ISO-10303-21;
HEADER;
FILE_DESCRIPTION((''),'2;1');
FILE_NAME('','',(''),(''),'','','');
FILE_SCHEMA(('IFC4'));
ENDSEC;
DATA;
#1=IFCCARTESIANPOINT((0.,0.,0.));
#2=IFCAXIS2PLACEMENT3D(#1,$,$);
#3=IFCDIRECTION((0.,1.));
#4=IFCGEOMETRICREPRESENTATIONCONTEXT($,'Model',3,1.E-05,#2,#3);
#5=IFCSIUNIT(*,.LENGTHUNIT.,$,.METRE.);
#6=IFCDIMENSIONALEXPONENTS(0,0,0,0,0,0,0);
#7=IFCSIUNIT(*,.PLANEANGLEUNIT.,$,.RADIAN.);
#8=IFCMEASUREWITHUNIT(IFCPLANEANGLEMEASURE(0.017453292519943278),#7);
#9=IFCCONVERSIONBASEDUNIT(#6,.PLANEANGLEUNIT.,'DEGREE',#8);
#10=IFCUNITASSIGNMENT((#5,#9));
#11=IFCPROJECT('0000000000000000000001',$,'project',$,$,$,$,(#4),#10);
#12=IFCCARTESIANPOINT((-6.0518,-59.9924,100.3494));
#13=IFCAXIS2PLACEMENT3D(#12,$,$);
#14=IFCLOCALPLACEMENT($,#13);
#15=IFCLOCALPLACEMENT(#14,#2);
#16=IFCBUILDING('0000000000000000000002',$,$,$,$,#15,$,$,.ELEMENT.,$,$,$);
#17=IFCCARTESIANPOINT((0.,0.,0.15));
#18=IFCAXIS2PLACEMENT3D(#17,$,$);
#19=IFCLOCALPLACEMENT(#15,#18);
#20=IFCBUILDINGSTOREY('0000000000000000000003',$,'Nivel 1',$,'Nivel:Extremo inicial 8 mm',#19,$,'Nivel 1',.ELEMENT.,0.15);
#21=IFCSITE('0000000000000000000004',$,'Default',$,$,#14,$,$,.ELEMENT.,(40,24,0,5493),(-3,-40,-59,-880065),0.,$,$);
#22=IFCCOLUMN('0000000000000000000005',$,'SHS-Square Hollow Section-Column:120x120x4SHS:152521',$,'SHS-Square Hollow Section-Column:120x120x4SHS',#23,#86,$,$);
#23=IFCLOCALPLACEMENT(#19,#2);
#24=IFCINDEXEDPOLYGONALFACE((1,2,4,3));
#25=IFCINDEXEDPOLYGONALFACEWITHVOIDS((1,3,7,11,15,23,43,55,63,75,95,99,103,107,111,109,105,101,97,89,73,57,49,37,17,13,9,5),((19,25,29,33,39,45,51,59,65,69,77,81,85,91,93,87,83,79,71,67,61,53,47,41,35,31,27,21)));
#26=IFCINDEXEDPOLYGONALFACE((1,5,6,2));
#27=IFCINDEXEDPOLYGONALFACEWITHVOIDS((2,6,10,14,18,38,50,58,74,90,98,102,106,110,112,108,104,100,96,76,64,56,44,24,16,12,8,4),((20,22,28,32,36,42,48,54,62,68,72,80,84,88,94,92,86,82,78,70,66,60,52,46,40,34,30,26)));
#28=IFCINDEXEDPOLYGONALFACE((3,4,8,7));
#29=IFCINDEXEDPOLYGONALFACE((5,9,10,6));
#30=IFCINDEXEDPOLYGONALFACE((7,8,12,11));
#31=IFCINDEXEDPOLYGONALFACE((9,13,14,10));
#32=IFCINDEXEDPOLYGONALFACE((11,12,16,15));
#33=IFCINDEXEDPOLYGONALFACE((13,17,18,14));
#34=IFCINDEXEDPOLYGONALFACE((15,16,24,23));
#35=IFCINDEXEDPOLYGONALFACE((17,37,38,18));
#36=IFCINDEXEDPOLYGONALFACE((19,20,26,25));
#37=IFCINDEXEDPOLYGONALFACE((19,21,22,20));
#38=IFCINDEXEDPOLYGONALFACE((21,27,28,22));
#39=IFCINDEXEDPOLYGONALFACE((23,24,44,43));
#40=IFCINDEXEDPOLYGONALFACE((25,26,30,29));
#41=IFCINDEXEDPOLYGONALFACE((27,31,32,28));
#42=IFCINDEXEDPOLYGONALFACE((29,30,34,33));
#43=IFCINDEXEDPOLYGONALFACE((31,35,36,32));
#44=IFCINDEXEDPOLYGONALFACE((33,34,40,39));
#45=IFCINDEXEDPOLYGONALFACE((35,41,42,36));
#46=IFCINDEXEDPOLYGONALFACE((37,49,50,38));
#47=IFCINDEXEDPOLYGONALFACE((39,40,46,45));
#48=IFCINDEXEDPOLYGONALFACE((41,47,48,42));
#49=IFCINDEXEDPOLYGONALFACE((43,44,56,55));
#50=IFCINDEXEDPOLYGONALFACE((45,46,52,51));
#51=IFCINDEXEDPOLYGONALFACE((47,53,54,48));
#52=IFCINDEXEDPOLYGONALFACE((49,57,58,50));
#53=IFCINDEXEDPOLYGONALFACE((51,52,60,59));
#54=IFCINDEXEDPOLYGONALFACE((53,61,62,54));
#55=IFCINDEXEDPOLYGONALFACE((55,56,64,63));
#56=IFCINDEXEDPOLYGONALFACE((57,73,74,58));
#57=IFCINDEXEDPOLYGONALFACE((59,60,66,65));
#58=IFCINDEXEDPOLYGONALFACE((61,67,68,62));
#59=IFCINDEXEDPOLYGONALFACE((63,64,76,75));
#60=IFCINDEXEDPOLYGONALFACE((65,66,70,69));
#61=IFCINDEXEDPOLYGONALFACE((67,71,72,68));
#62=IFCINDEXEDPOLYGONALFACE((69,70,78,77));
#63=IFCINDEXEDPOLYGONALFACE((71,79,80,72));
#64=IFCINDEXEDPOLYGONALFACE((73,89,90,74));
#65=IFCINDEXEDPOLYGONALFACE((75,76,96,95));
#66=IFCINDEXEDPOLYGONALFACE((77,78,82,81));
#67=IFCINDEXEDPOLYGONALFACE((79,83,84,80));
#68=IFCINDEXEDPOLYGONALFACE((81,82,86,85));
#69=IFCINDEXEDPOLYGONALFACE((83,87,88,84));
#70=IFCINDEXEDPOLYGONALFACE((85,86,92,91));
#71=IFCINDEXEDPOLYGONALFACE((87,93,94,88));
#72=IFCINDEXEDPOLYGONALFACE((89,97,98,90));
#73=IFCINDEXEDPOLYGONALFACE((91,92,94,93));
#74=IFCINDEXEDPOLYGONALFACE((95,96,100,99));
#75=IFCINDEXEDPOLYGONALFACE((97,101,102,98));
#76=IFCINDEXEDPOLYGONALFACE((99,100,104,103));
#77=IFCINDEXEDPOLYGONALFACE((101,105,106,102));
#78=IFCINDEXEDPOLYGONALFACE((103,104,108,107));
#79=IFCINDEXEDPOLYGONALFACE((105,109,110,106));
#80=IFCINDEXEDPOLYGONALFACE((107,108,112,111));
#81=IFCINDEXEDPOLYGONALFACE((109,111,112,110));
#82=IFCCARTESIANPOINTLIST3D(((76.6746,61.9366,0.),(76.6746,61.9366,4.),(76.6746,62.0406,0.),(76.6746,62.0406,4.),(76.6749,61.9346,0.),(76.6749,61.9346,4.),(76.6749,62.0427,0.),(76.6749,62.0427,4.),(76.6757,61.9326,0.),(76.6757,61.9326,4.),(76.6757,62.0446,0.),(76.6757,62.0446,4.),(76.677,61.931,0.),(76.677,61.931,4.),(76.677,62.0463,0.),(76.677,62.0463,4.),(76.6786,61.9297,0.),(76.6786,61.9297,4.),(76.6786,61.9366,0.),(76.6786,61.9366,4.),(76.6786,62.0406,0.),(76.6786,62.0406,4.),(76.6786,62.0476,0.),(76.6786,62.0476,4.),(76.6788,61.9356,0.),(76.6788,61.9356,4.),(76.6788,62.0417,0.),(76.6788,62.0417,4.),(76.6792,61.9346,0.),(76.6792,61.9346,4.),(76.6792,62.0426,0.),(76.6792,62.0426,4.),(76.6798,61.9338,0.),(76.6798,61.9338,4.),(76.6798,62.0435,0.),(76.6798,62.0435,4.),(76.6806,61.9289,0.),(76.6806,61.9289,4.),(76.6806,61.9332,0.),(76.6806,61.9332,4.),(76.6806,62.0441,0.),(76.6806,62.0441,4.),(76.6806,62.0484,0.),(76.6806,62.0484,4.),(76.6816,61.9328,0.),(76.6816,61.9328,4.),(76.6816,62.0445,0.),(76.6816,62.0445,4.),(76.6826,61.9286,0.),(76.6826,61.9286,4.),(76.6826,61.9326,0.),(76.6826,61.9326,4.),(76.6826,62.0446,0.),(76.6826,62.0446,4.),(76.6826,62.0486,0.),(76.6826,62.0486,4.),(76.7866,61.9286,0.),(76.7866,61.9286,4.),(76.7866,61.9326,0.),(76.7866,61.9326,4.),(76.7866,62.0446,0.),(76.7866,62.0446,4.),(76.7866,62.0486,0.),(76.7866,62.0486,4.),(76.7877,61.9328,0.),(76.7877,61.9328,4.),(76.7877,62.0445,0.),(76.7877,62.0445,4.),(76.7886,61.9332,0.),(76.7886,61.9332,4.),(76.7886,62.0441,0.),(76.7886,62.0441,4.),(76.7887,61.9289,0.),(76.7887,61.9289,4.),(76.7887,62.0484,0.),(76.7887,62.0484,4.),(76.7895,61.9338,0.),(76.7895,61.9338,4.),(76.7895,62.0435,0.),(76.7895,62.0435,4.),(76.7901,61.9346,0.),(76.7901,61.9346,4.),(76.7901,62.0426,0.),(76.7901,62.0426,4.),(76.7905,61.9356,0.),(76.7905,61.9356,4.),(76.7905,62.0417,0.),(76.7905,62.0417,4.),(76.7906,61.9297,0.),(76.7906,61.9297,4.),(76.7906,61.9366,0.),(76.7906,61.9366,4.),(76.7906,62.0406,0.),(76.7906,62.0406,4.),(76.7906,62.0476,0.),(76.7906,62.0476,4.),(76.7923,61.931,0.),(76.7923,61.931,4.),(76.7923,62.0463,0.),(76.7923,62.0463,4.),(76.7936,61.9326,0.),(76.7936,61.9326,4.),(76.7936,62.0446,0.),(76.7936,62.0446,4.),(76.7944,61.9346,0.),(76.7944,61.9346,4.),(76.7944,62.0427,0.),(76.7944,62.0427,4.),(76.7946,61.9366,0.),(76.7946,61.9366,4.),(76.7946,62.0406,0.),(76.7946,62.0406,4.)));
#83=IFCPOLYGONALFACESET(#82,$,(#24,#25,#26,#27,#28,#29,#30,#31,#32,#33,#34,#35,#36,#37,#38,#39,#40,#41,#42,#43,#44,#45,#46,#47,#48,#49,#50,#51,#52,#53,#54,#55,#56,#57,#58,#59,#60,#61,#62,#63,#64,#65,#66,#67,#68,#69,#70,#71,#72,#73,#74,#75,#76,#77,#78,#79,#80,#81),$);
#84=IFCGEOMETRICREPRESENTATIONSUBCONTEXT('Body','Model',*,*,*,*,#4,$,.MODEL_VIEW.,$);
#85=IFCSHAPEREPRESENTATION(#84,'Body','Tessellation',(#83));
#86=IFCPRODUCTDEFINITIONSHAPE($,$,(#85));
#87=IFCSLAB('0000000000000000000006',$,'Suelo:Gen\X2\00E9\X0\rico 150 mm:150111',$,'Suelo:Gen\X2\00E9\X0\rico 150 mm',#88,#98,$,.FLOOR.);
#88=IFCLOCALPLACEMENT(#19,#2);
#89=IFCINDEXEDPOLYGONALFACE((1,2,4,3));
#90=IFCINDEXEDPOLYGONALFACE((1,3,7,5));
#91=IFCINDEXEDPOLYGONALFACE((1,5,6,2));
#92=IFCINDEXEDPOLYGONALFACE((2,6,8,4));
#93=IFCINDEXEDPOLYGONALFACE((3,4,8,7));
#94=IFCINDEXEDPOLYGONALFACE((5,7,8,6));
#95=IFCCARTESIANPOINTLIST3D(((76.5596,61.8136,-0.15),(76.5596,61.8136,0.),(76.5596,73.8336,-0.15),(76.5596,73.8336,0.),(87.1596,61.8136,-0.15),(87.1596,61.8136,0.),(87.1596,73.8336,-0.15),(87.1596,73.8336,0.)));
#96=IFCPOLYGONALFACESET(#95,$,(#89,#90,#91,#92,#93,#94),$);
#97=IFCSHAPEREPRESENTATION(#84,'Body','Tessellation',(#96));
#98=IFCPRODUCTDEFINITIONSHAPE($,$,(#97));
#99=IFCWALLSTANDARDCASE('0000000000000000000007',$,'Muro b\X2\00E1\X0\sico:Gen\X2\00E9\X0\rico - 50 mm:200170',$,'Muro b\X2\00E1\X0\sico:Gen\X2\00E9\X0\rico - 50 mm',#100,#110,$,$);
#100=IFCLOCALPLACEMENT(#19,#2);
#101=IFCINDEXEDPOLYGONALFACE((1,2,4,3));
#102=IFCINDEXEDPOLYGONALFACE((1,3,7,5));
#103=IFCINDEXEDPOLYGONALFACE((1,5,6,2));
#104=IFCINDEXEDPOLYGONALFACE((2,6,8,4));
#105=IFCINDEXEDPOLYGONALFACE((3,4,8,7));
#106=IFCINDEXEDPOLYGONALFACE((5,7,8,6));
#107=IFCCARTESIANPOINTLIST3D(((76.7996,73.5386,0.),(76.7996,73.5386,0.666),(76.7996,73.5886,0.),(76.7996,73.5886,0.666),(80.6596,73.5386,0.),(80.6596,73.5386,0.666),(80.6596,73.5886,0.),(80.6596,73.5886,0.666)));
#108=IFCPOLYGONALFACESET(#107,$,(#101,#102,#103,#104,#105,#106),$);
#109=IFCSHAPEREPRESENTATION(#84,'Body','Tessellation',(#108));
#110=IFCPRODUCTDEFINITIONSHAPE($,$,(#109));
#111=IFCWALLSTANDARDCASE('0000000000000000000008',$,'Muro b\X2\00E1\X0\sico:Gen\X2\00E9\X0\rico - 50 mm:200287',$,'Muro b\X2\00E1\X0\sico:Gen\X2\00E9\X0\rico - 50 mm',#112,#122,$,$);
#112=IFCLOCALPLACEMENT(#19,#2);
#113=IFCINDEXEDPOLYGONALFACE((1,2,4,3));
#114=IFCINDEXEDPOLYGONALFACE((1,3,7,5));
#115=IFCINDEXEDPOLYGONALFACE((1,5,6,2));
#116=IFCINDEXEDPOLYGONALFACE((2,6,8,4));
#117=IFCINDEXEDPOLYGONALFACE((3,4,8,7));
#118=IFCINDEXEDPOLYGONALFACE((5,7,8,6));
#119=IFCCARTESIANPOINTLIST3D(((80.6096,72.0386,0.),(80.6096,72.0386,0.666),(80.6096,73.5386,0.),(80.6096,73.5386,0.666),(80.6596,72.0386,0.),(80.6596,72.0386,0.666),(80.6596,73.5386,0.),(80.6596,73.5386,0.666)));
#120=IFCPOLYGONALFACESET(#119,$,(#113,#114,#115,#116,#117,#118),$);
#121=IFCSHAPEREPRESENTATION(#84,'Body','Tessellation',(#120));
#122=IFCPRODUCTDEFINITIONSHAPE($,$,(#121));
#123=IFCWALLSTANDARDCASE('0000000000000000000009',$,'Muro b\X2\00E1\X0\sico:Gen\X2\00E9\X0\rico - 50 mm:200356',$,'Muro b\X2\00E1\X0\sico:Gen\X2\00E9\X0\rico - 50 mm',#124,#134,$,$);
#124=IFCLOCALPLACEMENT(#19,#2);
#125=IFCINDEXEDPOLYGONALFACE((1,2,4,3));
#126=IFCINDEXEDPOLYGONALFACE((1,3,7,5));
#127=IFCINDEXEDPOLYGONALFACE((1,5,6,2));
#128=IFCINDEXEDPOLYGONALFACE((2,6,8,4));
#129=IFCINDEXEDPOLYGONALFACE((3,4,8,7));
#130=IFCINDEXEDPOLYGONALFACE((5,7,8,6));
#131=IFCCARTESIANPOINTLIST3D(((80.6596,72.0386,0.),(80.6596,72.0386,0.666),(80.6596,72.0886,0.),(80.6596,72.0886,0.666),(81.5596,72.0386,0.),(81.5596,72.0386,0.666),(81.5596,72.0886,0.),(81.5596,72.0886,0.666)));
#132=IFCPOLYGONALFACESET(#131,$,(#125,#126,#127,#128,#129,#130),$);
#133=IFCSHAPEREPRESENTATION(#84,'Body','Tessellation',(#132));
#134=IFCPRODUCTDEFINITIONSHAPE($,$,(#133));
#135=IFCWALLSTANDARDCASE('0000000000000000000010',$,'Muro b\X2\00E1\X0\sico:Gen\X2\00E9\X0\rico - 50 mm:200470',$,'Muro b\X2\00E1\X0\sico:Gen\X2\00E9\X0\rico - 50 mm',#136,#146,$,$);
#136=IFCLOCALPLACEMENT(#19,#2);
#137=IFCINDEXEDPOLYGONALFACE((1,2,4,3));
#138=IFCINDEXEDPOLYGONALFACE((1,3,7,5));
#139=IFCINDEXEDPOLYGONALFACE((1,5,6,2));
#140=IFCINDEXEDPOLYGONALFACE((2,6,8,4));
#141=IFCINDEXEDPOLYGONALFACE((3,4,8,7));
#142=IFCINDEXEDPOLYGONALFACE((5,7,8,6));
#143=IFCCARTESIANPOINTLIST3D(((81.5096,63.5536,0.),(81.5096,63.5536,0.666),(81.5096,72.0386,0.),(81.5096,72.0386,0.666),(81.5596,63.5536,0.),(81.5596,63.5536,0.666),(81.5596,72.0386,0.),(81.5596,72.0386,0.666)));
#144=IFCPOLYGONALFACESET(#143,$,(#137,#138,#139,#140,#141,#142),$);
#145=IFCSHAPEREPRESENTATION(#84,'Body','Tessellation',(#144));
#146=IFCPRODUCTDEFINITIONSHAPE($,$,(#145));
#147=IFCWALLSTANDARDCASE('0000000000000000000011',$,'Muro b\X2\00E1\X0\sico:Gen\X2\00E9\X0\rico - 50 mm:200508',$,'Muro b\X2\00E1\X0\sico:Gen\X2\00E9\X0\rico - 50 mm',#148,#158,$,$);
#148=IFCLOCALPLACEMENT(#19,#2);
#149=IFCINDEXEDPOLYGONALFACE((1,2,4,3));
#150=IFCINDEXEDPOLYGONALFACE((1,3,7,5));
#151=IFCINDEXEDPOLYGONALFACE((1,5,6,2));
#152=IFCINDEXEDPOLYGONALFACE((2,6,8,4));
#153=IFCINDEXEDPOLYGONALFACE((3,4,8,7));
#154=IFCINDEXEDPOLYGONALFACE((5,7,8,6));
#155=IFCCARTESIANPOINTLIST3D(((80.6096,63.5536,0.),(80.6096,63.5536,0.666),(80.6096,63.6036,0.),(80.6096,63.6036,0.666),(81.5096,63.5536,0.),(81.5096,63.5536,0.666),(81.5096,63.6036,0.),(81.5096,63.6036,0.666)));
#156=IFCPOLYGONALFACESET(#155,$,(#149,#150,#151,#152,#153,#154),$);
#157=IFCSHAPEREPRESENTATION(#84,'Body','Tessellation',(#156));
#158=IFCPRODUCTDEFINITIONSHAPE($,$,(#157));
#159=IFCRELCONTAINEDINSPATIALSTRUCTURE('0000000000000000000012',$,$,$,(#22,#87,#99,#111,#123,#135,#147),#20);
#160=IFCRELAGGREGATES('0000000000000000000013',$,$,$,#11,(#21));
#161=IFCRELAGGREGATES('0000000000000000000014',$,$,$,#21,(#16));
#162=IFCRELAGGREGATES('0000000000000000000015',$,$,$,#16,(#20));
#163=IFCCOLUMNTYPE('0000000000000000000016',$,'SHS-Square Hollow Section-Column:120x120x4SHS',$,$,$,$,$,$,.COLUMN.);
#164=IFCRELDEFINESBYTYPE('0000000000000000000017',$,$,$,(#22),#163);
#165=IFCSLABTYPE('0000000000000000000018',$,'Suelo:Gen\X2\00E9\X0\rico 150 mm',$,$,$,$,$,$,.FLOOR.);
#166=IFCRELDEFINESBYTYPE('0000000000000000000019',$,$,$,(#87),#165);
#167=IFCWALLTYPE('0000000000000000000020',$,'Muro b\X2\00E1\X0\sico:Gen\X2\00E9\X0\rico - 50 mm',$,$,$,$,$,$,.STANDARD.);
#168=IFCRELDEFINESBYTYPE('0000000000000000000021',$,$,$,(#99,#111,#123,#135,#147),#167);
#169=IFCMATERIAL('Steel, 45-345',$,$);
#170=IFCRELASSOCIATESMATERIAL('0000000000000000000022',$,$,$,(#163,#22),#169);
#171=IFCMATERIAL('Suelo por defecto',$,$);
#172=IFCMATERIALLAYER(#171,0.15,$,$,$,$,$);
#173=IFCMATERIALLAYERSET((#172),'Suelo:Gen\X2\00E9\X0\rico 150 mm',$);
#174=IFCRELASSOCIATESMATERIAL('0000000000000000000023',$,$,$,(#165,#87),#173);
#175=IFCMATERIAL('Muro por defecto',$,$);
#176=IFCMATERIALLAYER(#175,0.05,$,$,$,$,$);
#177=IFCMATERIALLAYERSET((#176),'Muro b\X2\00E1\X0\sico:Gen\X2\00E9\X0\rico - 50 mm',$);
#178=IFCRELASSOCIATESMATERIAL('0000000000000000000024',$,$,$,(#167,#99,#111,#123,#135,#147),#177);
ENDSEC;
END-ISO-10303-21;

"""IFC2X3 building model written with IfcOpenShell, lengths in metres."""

from ifc_helpers import new_model, entity, si_unit, converted_unit, direction, frame, frame_2d, origin, place, context, subcontext, project, spatial, polyline, circle_curve, parameter, trimmed, segment, composite_curve, rectangle, outline, extrude, clip, bounded_halfspace, source, transform, mapped, material, layer, layer_set, layer_usage, type_object, type_shapes, element, save


model = new_model("IFC2X3")

# Units and contexts
model_context = context("Model", 3, precision=1e-05, world=origin(), true_north=direction((0.0, 1.0)))
body_context = subcontext(model_context, "Body", "Model", "MODEL_VIEW")
ifc_project = project(units=[si_unit("LENGTHUNIT", "METRE"), converted_unit("PLANEANGLEUNIT", "DEGREE", entity("IfcPlaneAngleMeasure", 0.017453292519943278), si_unit("PLANEANGLEUNIT", "RADIAN"), dimensions=[0, 0, 0, 0, 0, 0, 0])], contexts=[model_context])

# Site, building, storey
site_placement = place(None, frame((-6.0518, -59.9924, 100.3494)))
site = spatial("IfcSite", under=ifc_project, at=site_placement, Name="Default", CompositionType="ELEMENT", RefLatitude=(40, 24, 0, 5493), RefLongitude=(-3, -40, -59, -880065), RefElevation=0.0)
building_placement = place(site_placement, origin())
building = spatial("IfcBuilding", under=site, at=building_placement, CompositionType="ELEMENT")
storey_placement = place(building_placement, frame((0.0, 0.0, 0.15)))
storey = spatial("IfcBuildingStorey", under=building, at=storey_placement, Name="Nivel 1", ObjectType="Nivel:Extremo inicial 8 mm", LongName="Nivel 1", CompositionType="ELEMENT", Elevation=0.15)

# Column
ifc_material_1 = material(Name="Steel, 45-345")
column_type = type_object("IfcColumnType", Name="SHS-Square Hollow Section-Column:120x120x4SHS", PredefinedType="COLUMN", material=ifc_material_1)
shared_shape_1 = source(origin(), body_context, "Body", "SweptSolid", [
    extrude(outline(composite_curve([segment(polyline([(-0.052, -0.06), (0.052, -0.06)]), True, "CONTINUOUS"), segment(trimmed(circle_curve(frame_2d((0.052, -0.052), x_axis=(-1.0, 0.0)), 0.008), [parameter(90.0)], [parameter(180.0)], True, "PARAMETER"), True, "CONTINUOUS"), segment(polyline([(0.06, -0.052), (0.06, 0.052)]), True, "CONTINUOUS"), segment(trimmed(circle_curve(frame_2d((0.052, 0.052), x_axis=(-1.0, 0.0)), 0.008), [parameter(180.0)], [parameter(270.0)], True, "PARAMETER"), True, "CONTINUOUS"), segment(polyline([(0.052, 0.06), (-0.052, 0.06)]), True, "CONTINUOUS"), segment(trimmed(circle_curve(frame_2d((-0.052, 0.052), x_axis=(-1.0, 0.0)), 0.008), [parameter(270.0)], [parameter(360.0)], True, "PARAMETER"), True, "CONTINUOUS"), segment(polyline([(-0.06, 0.052), (-0.06, -0.052)]), True, "CONTINUOUS"), segment(trimmed(circle_curve(frame_2d((-0.052, -0.052), x_axis=(-1.0, 0.0)), 0.008), [parameter(360.0)], [parameter(90.0)], True, "PARAMETER"), True, "CONTINUOUS")], self_intersect=False), holes=[composite_curve([segment(trimmed(circle_curve(frame_2d((-0.052, -0.052), x_axis=(-1.0, 0.0)), 0.004), [parameter(0.0)], [parameter(90.0)], True, "PARAMETER"), False, "CONTINUOUS"), segment(polyline([(-0.056, -0.052), (-0.056, 0.052)]), True, "CONTINUOUS"), segment(trimmed(circle_curve(frame_2d((-0.052, 0.052), x_axis=(-1.0, 0.0)), 0.004), [parameter(270.0)], [parameter(0.0)], True, "PARAMETER"), False, "CONTINUOUS"), segment(polyline([(-0.052, 0.056), (0.052, 0.056)]), True, "CONTINUOUS"), segment(trimmed(circle_curve(frame_2d((0.052, 0.052), x_axis=(-1.0, 0.0)), 0.004), [parameter(180.0)], [parameter(270.0)], True, "PARAMETER"), False, "CONTINUOUS"), segment(polyline([(0.056, 0.052), (0.056, -0.052)]), True, "CONTINUOUS"), segment(trimmed(circle_curve(frame_2d((0.052, -0.052), x_axis=(-1.0, 0.0)), 0.004), [parameter(90.0)], [parameter(180.0)], True, "PARAMETER"), False, "CONTINUOUS"), segment(polyline([(0.052, -0.056), (-0.052, -0.056)]), True, "CONTINUOUS")], self_intersect=False)]), frame((76.7346, 61.9886, 0.15), z_axis=(0.0, 0.0, 1.0), x_axis=(-1.0, 0.0, 0.0)), (0.0, 0.0, 1.0), 4.0),
])
type_shapes(column_type, [shared_shape_1])
column_placement = place(storey_placement, frame((0.0, 0.0, -0.15)))
element("IfcColumn", 1, at=column_placement, inside=storey, type_object=column_type, material=ifc_material_1, Name="SHS-Square Hollow Section-Column:120x120x4SHS:152521", ObjectType="SHS-Square Hollow Section-Column:120x120x4SHS", context=body_context, shape_type="MappedRepresentation", body=[
    mapped(shared_shape_1, transform((0.0, 0.0, 0.0), scale=1.0)),
])

# Slab
ifc_material_2 = material(Name="Suelo por defecto")
ifc_layer_1 = layer(ifc_material_2, 0.15)
ifc_layer_set_1 = layer_set([ifc_layer_1], Name="Suelo:Genérico 150 mm")
ifc_layer_usage_1 = layer_usage(ifc_layer_set_1, "AXIS3", "POSITIVE", 0.0)
slab_type_1 = type_object("IfcSlabType", Name="Suelo:Genérico 150 mm", PredefinedType="FLOOR", material=ifc_layer_set_1)
slab_1_placement = place(storey_placement, origin())
element("IfcSlab", 2, at=slab_1_placement, inside=storey, type_object=slab_type_1, material=ifc_layer_usage_1, Name="Suelo:Genérico 150 mm:150111", ObjectType="Suelo:Genérico 150 mm", PredefinedType="FLOOR", context=body_context, shape_type="SweptSolid", body=[
    extrude(rectangle(XDim=12.02, YDim=10.6, at=frame_2d((0.0, 0.0), x_axis=(1.0, 0.0))), frame((81.8596, 67.8236, 0.0), z_axis=(0.0, 0.0, -1.0), x_axis=(0.0, 1.0, 0.0)), (0.0, 0.0, 1.0), 0.15),
])

# Walls
ifc_material_3 = material(Name="Muro por defecto")
ifc_layer_2 = layer(ifc_material_3, 0.05)
ifc_layer_set_2 = layer_set([ifc_layer_2], Name="Muro básico:Genérico - 50 mm")
ifc_layer_usage_2 = layer_usage(ifc_layer_set_2, "AXIS2", "POSITIVE", -0.025)
wall_type = type_object("IfcWallType", Name="Muro básico:Genérico - 50 mm", PredefinedType="STANDARD", material=ifc_layer_set_2)
wall_1_placement = place(storey_placement, frame((76.7996, 73.5636, 0.0)))
element("IfcWallStandardCase", 3, at=wall_1_placement, inside=storey, type_object=wall_type, material=ifc_layer_usage_2, Name="Muro básico:Genérico - 50 mm:200170", ObjectType="Muro básico:Genérico - 50 mm", context=body_context, shape_type="Clipping", body=[
    clip(extrude(rectangle(XDim=3.86, YDim=0.05, at=frame_2d((1.93, 0.0), x_axis=(-1.0, 0.0))), origin(), (0.0, 0.0, 1.0), 0.666), bounded_halfspace(frame((0.0, -0.025, 0.666), z_axis=(0.0, 0.0, -1.0), x_axis=(1.0, 0.0, 0.0)), True, frame((0.0, -0.025, 0.666), z_axis=(0.0, 0.0, -1.0), x_axis=(1.0, 0.0, 0.0)), polyline([(0.0, 0.0), (0.0, -0.05), (3.86, -0.05), (3.86, 0.0), (3.81, 0.0), (0.05, 0.0), (0.0, 0.0)]))),
])
ifc_layer_usage_3 = layer_usage(ifc_layer_set_2, "AXIS2", "POSITIVE", -0.025)
wall_2_placement = place(storey_placement, frame((80.6346, 73.5386, 0.0), z_axis=(0.0, 0.0, 1.0), x_axis=(0.0, -1.0, 0.0)))
element("IfcWallStandardCase", 4, at=wall_2_placement, inside=storey, type_object=wall_type, material=ifc_layer_usage_3, Name="Muro básico:Genérico - 50 mm:200287", ObjectType="Muro básico:Genérico - 50 mm", context=body_context, shape_type="Clipping", body=[
    clip(extrude(rectangle(XDim=1.5, YDim=0.05, at=frame_2d((0.75, 0.0), x_axis=(-1.0, 0.0))), origin(), (0.0, 0.0, 1.0), 0.666), bounded_halfspace(frame((0.0, -0.025, 0.666), z_axis=(0.0, 0.0, -1.0), x_axis=(0.0, 1.0, 0.0)), True, frame((0.0, -0.025, 0.666), z_axis=(0.0, 0.0, -1.0), x_axis=(0.0, 1.0, 0.0)), polyline([(0.0, 0.0), (0.05, 0.0), (0.05, 1.45), (0.05, 1.5), (0.0, 1.5), (0.0, 0.0)]))),
])
ifc_layer_usage_4 = layer_usage(ifc_layer_set_2, "AXIS2", "NEGATIVE", 0.025)
wall_3_placement = place(storey_placement, frame((80.6596, 72.0636, 0.0)))
element("IfcWallStandardCase", 5, at=wall_3_placement, inside=storey, type_object=wall_type, material=ifc_layer_usage_4, Name="Muro básico:Genérico - 50 mm:200356", ObjectType="Muro básico:Genérico - 50 mm", context=body_context, shape_type="Clipping", body=[
    clip(extrude(rectangle(XDim=0.9, YDim=0.05, at=frame_2d((0.45, 0.0), x_axis=(-1.0, 0.0))), origin(), (0.0, 0.0, 1.0), 0.666), bounded_halfspace(frame((0.0, -0.025, 0.666), z_axis=(0.0, 0.0, -1.0), x_axis=(1.0, 0.0, 0.0)), True, frame((0.0, -0.025, 0.666), z_axis=(0.0, 0.0, -1.0), x_axis=(1.0, 0.0, 0.0)), polyline([(0.0, 0.0), (0.0, -0.05), (0.9, -0.05), (0.9, 0.0), (0.0, 0.0)]))),
])
ifc_layer_usage_5 = layer_usage(ifc_layer_set_2, "AXIS2", "POSITIVE", -0.025)
wall_4_placement = place(storey_placement, frame((81.5346, 72.0386, 0.0), z_axis=(0.0, 0.0, 1.0), x_axis=(0.0, -1.0, 0.0)))
element("IfcWallStandardCase", 6, at=wall_4_placement, inside=storey, type_object=wall_type, material=ifc_layer_usage_5, Name="Muro básico:Genérico - 50 mm:200470", ObjectType="Muro básico:Genérico - 50 mm", context=body_context, shape_type="Clipping", body=[
    clip(extrude(rectangle(XDim=8.485, YDim=0.05, at=frame_2d((4.2425, 0.0), x_axis=(-1.0, 0.0))), origin(), (0.0, 0.0, 1.0), 0.666), bounded_halfspace(frame((0.0, -0.025, 0.666), z_axis=(0.0, 0.0, -1.0), x_axis=(0.0, 1.0, 0.0)), True, frame((0.0, -0.025, 0.666), z_axis=(0.0, 0.0, -1.0), x_axis=(0.0, 1.0, 0.0)), polyline([(0.0, 0.0), (0.05, 0.0), (0.05, 8.485), (0.0, 8.485), (0.0, 0.0)]))),
])
ifc_layer_usage_6 = layer_usage(ifc_layer_set_2, "AXIS2", "NEGATIVE", 0.025)
wall_5_placement = place(storey_placement, frame((81.5096, 63.5786, 0.0), z_axis=(0.0, 0.0, 1.0), x_axis=(-1.0, 0.0, 0.0)))
element("IfcWallStandardCase", 7, at=wall_5_placement, inside=storey, type_object=wall_type, material=ifc_layer_usage_6, Name="Muro básico:Genérico - 50 mm:200508", ObjectType="Muro básico:Genérico - 50 mm", context=body_context, shape_type="Clipping", body=[
    clip(extrude(rectangle(XDim=0.9, YDim=0.05, at=frame_2d((0.45, 0.0), x_axis=(-1.0, 0.0))), origin(), (0.0, 0.0, 1.0), 0.666), bounded_halfspace(frame((0.0, -0.025, 0.666), z_axis=(0.0, 0.0, -1.0), x_axis=(-1.0, 0.0, 0.0)), True, frame((0.0, -0.025, 0.666), z_axis=(0.0, 0.0, -1.0), x_axis=(-1.0, 0.0, 0.0)), polyline([(0.0, 0.0), (0.0, 0.05), (-0.85, 0.05), (-0.9, 0.05), (-0.9, 0.0), (0.0, 0.0)]))),
])

save(model, "model.ifc")
